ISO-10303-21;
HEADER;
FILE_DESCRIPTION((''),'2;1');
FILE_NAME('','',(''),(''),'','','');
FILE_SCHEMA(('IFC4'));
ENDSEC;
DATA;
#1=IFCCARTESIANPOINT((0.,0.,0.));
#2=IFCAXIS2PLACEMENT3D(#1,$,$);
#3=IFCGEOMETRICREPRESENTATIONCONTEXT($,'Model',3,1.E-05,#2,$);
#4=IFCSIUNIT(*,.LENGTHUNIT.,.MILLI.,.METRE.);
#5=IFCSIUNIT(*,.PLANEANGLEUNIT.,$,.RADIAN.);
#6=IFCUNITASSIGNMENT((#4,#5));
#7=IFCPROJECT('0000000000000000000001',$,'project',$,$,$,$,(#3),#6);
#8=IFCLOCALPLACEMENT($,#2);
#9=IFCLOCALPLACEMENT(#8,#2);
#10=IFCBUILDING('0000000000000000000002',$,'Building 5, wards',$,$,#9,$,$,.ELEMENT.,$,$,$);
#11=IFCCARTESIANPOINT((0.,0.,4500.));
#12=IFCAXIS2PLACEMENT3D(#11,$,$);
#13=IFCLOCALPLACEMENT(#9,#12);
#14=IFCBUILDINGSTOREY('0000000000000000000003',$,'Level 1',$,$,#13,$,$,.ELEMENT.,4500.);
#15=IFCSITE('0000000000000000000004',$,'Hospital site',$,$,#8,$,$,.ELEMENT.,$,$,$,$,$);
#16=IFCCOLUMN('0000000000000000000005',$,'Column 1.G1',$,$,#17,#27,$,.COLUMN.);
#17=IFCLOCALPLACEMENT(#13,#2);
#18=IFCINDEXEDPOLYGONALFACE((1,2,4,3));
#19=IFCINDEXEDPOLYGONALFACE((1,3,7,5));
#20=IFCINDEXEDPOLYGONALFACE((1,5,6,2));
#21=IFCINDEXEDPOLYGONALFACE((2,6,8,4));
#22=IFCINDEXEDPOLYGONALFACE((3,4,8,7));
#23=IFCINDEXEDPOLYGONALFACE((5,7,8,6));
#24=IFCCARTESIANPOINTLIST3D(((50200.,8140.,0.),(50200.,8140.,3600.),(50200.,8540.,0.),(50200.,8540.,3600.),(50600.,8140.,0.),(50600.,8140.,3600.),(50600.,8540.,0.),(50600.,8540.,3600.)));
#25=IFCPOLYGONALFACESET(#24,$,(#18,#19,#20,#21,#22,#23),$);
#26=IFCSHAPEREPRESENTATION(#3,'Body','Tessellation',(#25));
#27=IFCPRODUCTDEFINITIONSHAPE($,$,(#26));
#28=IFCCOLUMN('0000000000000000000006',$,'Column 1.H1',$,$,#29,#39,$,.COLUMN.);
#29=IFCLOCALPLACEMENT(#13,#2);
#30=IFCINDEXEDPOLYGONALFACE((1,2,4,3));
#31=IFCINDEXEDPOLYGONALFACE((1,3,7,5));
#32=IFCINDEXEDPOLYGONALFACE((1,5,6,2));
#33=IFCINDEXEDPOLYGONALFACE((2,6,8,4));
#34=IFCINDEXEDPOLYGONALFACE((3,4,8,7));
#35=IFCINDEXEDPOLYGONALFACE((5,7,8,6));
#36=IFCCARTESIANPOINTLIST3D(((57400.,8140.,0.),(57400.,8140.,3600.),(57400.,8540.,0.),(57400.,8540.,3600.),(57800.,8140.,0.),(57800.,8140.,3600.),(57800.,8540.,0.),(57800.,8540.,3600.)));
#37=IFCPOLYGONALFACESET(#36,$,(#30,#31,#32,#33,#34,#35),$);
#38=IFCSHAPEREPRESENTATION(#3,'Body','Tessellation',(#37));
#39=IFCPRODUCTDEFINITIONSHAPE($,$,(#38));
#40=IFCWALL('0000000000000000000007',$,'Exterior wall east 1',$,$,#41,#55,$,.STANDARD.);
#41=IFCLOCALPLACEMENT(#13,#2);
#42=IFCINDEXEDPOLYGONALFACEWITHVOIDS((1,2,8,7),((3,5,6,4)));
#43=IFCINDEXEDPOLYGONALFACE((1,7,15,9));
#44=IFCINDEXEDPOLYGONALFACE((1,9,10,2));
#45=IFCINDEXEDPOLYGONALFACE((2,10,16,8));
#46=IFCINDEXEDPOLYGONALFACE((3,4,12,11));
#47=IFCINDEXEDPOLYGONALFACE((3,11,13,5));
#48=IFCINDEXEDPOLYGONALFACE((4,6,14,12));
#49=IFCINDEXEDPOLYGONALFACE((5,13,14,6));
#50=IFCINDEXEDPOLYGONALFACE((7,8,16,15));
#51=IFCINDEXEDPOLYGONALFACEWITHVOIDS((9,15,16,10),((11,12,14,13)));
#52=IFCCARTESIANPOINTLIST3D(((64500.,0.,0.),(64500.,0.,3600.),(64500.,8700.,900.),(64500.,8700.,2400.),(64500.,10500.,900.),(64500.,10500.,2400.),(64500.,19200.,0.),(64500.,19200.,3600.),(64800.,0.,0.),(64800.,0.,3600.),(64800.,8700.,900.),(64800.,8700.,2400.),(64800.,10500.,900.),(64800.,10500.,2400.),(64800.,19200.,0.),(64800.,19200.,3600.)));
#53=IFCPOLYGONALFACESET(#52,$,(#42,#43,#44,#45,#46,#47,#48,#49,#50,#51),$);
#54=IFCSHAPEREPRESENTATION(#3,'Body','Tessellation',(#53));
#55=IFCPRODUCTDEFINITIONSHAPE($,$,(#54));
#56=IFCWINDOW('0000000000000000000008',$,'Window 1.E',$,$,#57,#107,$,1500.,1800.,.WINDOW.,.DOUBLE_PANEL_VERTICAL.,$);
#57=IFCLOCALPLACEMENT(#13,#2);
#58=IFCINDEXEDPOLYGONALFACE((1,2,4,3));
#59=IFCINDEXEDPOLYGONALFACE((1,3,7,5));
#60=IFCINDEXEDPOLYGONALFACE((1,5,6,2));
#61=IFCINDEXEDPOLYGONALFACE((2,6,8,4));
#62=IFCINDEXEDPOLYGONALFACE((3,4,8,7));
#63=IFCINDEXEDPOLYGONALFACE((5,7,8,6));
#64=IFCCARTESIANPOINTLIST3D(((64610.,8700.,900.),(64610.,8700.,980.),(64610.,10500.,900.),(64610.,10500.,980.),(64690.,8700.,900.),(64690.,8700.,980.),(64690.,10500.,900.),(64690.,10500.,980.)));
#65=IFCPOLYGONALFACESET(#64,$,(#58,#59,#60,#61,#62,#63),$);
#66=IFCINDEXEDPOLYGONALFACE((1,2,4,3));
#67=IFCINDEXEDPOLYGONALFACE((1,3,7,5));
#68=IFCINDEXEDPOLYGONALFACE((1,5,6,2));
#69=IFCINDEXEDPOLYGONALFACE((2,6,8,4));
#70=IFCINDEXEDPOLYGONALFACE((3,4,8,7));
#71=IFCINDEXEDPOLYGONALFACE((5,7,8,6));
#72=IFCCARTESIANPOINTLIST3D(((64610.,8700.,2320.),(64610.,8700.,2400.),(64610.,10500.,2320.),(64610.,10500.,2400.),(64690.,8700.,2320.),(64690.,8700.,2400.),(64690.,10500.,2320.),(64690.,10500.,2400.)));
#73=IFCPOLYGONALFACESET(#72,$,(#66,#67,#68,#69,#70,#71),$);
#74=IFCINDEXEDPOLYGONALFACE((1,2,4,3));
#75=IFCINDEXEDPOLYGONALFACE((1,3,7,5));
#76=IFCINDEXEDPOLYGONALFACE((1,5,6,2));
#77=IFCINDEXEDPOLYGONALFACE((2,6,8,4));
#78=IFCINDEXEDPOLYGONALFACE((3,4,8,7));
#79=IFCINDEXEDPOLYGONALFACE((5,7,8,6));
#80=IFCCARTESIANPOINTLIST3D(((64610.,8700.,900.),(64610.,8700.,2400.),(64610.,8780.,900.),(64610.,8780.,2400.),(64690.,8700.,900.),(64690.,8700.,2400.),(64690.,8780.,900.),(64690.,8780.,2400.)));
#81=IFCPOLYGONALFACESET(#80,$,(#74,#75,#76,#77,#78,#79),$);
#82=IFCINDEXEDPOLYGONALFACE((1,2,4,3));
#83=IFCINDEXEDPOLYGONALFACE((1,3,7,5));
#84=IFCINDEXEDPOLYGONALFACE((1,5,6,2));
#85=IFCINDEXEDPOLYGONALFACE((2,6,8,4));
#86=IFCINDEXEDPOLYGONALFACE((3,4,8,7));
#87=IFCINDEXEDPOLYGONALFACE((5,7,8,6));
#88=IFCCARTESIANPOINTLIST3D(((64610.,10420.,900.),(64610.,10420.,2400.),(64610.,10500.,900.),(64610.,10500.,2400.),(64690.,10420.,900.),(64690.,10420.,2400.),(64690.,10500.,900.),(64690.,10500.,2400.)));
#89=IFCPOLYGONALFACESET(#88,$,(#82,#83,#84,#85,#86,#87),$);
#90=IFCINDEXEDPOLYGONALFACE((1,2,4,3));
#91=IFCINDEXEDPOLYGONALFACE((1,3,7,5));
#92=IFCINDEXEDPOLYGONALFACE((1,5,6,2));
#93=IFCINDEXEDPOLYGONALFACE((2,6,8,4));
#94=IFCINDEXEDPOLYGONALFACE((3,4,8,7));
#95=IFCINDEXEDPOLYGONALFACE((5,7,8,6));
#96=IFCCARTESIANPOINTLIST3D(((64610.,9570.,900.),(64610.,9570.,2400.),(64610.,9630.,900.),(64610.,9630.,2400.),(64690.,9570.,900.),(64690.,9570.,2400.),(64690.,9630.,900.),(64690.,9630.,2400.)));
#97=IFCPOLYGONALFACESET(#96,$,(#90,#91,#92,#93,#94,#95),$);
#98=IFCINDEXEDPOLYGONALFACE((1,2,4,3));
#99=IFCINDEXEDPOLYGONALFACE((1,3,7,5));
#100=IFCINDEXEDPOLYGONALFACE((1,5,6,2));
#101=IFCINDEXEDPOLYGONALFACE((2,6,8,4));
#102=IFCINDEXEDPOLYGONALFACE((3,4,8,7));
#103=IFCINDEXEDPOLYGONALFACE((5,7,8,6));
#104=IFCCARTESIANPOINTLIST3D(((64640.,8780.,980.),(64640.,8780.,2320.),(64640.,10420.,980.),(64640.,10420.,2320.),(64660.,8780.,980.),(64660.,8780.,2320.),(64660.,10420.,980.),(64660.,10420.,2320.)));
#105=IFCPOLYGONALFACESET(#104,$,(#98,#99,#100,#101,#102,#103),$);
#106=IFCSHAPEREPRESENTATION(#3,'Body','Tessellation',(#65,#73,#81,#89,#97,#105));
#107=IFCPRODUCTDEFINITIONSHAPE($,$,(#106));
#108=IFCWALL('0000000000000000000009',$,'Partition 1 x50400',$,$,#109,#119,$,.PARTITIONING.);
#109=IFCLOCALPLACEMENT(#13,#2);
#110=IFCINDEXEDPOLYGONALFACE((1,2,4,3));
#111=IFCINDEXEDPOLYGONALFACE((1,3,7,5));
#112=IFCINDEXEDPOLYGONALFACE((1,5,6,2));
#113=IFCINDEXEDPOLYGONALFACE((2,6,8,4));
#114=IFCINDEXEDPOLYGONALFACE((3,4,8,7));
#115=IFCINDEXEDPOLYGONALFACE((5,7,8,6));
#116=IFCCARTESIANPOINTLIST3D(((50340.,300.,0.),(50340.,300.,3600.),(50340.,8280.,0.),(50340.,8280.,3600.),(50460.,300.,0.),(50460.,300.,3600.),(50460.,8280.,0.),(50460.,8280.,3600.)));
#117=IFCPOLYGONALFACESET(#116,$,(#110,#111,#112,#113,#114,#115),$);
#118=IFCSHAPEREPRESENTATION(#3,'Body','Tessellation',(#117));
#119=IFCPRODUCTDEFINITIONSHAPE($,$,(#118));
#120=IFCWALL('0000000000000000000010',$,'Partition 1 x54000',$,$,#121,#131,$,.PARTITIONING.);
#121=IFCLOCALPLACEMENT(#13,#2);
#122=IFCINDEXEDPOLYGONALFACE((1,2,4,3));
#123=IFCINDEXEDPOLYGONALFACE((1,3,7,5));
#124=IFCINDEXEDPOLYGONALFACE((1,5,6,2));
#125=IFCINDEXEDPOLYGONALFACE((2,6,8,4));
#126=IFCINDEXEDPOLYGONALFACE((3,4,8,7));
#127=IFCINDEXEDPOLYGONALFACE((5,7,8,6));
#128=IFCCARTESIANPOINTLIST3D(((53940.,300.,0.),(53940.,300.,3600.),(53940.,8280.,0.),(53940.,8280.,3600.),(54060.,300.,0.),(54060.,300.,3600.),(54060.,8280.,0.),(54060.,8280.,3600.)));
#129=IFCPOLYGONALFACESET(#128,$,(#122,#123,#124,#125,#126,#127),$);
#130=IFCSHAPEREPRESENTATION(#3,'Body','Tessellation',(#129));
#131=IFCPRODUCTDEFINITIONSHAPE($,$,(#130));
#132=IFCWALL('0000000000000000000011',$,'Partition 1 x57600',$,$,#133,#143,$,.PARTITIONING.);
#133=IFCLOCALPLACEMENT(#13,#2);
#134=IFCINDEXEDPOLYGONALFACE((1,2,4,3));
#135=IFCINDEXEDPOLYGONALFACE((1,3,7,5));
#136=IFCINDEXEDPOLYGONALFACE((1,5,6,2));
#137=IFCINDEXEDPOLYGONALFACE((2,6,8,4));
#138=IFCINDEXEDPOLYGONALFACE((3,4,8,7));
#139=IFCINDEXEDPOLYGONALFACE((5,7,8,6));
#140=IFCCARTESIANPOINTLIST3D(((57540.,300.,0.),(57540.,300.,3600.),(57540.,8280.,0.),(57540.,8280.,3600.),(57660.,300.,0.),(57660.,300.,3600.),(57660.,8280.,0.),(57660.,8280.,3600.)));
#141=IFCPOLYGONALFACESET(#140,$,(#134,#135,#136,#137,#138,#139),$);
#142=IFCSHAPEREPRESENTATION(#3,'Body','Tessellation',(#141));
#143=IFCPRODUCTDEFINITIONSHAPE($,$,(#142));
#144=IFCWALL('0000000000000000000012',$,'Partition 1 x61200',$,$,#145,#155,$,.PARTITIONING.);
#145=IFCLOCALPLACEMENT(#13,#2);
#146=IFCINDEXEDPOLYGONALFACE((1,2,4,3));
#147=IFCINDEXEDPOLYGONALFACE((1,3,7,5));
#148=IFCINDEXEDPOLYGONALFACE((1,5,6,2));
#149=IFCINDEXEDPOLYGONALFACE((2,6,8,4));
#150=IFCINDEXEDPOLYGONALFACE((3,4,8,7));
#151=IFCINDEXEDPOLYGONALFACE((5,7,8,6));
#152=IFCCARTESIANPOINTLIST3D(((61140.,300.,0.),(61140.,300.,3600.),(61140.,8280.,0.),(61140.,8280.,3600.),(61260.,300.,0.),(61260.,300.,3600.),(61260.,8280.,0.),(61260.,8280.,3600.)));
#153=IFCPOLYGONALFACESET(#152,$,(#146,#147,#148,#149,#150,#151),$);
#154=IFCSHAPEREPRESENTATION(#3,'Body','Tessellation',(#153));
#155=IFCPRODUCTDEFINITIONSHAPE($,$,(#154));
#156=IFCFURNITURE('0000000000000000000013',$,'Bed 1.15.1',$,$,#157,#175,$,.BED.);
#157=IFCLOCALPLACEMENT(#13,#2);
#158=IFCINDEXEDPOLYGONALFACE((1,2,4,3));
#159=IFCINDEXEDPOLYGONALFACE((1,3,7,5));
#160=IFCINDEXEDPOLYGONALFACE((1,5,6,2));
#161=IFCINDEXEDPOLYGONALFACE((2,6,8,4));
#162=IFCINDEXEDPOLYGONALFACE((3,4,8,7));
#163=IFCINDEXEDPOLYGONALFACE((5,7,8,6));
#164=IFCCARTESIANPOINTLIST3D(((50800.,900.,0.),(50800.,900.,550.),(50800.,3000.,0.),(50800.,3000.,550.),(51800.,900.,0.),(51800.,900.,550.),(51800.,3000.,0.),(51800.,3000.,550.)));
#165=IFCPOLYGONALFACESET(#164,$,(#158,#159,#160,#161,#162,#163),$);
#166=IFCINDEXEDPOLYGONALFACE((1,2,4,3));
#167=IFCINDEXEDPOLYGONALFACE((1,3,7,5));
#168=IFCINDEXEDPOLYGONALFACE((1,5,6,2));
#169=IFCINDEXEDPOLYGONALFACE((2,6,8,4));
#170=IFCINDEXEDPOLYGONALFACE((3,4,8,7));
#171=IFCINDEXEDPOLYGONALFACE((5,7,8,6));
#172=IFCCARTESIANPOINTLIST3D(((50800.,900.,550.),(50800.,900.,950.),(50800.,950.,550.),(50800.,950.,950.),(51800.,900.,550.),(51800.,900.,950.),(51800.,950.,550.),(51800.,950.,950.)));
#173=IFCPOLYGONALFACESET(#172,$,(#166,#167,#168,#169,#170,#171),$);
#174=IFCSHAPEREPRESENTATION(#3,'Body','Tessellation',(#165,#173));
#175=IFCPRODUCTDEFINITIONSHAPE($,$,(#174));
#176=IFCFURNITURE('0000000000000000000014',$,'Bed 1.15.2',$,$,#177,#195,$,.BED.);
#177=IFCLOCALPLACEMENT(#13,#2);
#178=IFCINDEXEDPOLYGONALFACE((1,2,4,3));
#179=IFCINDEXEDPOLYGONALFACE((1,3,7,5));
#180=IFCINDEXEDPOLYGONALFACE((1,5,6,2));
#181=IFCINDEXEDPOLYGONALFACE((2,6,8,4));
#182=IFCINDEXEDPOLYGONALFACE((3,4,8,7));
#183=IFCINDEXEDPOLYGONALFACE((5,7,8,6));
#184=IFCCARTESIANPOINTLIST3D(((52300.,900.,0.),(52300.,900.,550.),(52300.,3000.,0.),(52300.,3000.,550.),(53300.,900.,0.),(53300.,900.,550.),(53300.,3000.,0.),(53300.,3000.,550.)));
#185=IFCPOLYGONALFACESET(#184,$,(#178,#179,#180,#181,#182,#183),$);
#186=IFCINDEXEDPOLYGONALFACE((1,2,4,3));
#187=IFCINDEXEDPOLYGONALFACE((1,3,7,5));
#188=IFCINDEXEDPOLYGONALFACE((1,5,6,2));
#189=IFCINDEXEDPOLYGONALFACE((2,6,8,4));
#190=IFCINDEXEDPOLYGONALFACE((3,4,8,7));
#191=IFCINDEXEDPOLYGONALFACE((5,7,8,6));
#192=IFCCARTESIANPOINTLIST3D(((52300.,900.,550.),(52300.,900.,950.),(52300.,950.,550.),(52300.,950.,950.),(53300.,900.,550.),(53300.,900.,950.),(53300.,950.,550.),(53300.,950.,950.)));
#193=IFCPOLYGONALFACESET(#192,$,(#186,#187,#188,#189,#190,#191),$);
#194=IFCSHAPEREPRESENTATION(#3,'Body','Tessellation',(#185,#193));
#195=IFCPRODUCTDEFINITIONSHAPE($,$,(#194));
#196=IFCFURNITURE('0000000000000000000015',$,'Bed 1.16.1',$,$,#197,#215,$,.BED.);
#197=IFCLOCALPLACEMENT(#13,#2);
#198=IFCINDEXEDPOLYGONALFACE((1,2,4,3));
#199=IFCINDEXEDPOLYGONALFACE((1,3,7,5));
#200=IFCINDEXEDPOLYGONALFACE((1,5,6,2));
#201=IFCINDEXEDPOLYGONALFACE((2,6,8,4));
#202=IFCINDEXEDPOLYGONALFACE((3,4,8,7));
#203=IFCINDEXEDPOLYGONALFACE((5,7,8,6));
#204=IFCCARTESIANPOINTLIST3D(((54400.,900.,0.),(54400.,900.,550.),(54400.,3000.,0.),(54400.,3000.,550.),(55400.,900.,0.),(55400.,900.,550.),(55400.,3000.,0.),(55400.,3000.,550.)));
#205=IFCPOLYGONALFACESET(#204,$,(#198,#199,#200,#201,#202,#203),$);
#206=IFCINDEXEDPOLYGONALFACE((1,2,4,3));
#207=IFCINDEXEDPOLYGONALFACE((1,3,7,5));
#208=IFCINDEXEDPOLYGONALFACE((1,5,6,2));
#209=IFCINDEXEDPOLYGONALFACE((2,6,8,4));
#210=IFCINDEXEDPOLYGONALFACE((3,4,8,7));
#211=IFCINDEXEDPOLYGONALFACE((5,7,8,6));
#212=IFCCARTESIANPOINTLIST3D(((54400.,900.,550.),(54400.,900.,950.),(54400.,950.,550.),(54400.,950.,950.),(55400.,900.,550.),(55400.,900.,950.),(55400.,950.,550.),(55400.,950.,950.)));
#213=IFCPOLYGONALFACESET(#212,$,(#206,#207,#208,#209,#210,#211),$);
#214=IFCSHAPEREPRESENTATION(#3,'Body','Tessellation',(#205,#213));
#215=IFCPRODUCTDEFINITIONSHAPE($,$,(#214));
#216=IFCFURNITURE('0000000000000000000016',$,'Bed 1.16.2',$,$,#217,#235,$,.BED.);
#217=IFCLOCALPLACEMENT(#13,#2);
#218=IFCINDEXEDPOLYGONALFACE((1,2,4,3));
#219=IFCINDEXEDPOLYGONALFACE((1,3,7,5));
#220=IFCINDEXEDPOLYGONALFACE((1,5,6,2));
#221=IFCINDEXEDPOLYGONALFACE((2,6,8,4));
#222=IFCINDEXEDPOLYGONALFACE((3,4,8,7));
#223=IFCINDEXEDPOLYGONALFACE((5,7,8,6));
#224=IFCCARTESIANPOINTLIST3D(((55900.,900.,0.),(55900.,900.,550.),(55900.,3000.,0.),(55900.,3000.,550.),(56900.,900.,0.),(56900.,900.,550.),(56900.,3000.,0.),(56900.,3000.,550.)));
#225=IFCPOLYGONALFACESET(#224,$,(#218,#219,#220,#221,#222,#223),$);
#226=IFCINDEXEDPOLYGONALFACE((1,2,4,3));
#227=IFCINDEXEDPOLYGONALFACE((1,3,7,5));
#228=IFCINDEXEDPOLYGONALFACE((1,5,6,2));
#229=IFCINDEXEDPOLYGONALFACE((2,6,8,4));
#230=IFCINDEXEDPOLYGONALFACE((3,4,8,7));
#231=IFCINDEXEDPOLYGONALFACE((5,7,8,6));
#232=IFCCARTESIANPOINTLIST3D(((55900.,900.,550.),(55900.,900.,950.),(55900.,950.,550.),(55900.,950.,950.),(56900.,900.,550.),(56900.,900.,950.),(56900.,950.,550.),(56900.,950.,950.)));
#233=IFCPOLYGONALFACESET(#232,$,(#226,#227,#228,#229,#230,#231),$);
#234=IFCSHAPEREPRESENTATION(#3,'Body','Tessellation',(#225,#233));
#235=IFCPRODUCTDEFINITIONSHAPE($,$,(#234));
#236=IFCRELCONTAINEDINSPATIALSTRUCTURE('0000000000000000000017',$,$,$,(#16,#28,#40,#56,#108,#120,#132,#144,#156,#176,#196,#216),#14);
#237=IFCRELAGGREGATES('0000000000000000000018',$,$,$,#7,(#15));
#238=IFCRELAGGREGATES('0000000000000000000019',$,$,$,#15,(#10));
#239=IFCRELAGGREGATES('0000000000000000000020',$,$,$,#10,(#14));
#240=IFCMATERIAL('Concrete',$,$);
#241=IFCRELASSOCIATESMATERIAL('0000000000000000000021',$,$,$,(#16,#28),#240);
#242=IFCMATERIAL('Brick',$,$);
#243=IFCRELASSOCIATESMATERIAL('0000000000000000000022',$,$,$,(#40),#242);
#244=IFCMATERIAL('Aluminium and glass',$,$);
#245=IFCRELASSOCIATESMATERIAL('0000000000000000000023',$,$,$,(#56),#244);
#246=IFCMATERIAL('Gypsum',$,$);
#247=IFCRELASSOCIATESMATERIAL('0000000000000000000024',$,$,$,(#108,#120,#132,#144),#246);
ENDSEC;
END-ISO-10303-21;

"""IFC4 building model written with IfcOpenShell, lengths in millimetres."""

from ifc_helpers import new_model, si_unit, frame, frame_2d, origin, origin_2d, place, context, project, spatial, rectangle, extrude, material, element, fill, save


model = new_model("IFC4")

# Units and contexts
model_context = context("Model", 3, precision=1e-05, world=origin())
ifc_project = project(units=[si_unit("LENGTHUNIT", "METRE", prefix="MILLI"), si_unit("PLANEANGLEUNIT", "RADIAN")], contexts=[model_context])

# Site, building, storey
site_placement = place(None, origin())
site = spatial("IfcSite", under=ifc_project, at=site_placement, Name="Hospital site", CompositionType="ELEMENT")
building_placement = place(site_placement, origin())
building = spatial("IfcBuilding", under=site, at=building_placement, Name="Building 5, wards", CompositionType="ELEMENT")
storey_placement = place(building_placement, frame((0.0, 0.0, 4500.0)))
storey = spatial("IfcBuildingStorey", under=building, at=storey_placement, Name="Level 1", CompositionType="ELEMENT", Elevation=4500.0)

# Columns
ifc_material_1 = material(Name="Concrete")
for number, where, name in (
    (1, (50400.0, 8340.0, 0.0), "Column 1.G1"),
    (2, (57600.0, 8340.0, 0.0), "Column 1.H1"),
):
    element("IfcColumn", number, at=place(storey_placement, frame(where)), inside=storey, material=ifc_material_1, Name=name, PredefinedType="COLUMN", context=model_context, shape_type="SweptSolid", body=[
        extrude(rectangle(XDim=400.0, YDim=400.0, at=origin_2d()), origin(), (0.0, 0.0, 1.0), 3600.0),
    ])

# Wall, opening, window
ifc_material_2 = material(Name="Brick")
wall_placement = place(storey_placement, frame((64800.0, 0.0, 0.0), x_axis=(0.0, 1.0, 0.0)))
wall = element("IfcWall", 3, at=wall_placement, inside=storey, material=ifc_material_2, Name="Exterior wall east 1", PredefinedType="STANDARD", context=model_context, shape_type="SweptSolid", body=[
    extrude(rectangle(XDim=19200.0, YDim=300.0, at=frame_2d((9600.0, 150.0))), origin(), (0.0, 0.0, 1.0), 3600.0),
])
opening_placement = place(wall_placement, frame((8700.0, -50.0, 900.0)))
opening = element("IfcOpeningElement", 4, at=opening_placement, cuts=wall, PredefinedType="OPENING", context=model_context, shape_type="SweptSolid", body=[
    extrude(rectangle(XDim=1800.0, YDim=400.0, at=frame_2d((900.0, 200.0))), origin(), (0.0, 0.0, 1.0), 1500.0),
])
ifc_material_3 = material(Name="Aluminium and glass")
window_placement = place(opening_placement, frame((0.0, 160.0, 0.0)))
window = element("IfcWindow", 5, at=window_placement, inside=storey, material=ifc_material_3, Name="Window 1.E", OverallHeight=1500.0, OverallWidth=1800.0, PartitioningType="DOUBLE_PANEL_VERTICAL", PredefinedType="WINDOW", context=model_context, shape_type="SweptSolid", body=[
    extrude(rectangle(XDim=1800.0, YDim=80.0, at=frame_2d((900.0, 40.0))), origin(), (0.0, 0.0, 1.0), 80.0),
    extrude(rectangle(XDim=1800.0, YDim=80.0, at=frame_2d((900.0, 40.0))), frame((0.0, 0.0, 1420.0)), (0.0, 0.0, 1.0), 80.0),
    extrude(rectangle(XDim=80.0, YDim=80.0, at=frame_2d((40.0, 40.0))), origin(), (0.0, 0.0, 1.0), 1500.0),
    extrude(rectangle(XDim=80.0, YDim=80.0, at=frame_2d((1760.0, 40.0))), origin(), (0.0, 0.0, 1.0), 1500.0),
    extrude(rectangle(XDim=60.0, YDim=80.0, at=frame_2d((900.0, 40.0))), origin(), (0.0, 0.0, 1.0), 1500.0),
    extrude(rectangle(XDim=1640.0, YDim=20.0, at=frame_2d((900.0, 40.0))), frame((0.0, 0.0, 80.0)), (0.0, 0.0, 1.0), 1340.0),
])
fill(opening, window)

# Walls
ifc_material_4 = material(Name="Gypsum")
for number, where, x_axis, name in (
    (6, (50460.0, 300.0, 0.0), (0.0, 1.0, 0.0), "Partition 1 x50400"),
    (7, (54060.0, 300.0, 0.0), (0.0, 1.0, 0.0), "Partition 1 x54000"),
    (8, (57660.0, 300.0, 0.0), (0.0, 1.0, 0.0), "Partition 1 x57600"),
    (9, (61260.0, 300.0, 0.0), (0.0, 1.0, 0.0), "Partition 1 x61200"),
):
    element("IfcWall", number, at=place(storey_placement, frame(where, x_axis=x_axis)), inside=storey, material=ifc_material_4, Name=name, PredefinedType="PARTITIONING", context=model_context, shape_type="SweptSolid", body=[
        extrude(rectangle(XDim=7980.0, YDim=120.0, at=frame_2d((3990.0, 60.0))), origin(), (0.0, 0.0, 1.0), 3600.0),
    ])

# Furniture
for number, where, name in (
    (10, (50800.0, 900.0, 0.0), "Bed 1.15.1"),
    (11, (52300.0, 900.0, 0.0), "Bed 1.15.2"),
    (12, (54400.0, 900.0, 0.0), "Bed 1.16.1"),
    (13, (55900.0, 900.0, 0.0), "Bed 1.16.2"),
):
    element("IfcFurniture", number, at=place(storey_placement, frame(where)), inside=storey, Name=name, PredefinedType="BED", context=model_context, shape_type="SweptSolid", body=[
        extrude(rectangle(XDim=1000.0, YDim=2100.0, at=frame_2d((500.0, 1050.0))), origin(), (0.0, 0.0, 1.0), 550.0),
        extrude(rectangle(XDim=1000.0, YDim=50.0, at=frame_2d((500.0, 25.0))), frame((0.0, 0.0, 550.0)), (0.0, 0.0, 1.0), 400.0),
    ])

save(model, "model.ifc")
